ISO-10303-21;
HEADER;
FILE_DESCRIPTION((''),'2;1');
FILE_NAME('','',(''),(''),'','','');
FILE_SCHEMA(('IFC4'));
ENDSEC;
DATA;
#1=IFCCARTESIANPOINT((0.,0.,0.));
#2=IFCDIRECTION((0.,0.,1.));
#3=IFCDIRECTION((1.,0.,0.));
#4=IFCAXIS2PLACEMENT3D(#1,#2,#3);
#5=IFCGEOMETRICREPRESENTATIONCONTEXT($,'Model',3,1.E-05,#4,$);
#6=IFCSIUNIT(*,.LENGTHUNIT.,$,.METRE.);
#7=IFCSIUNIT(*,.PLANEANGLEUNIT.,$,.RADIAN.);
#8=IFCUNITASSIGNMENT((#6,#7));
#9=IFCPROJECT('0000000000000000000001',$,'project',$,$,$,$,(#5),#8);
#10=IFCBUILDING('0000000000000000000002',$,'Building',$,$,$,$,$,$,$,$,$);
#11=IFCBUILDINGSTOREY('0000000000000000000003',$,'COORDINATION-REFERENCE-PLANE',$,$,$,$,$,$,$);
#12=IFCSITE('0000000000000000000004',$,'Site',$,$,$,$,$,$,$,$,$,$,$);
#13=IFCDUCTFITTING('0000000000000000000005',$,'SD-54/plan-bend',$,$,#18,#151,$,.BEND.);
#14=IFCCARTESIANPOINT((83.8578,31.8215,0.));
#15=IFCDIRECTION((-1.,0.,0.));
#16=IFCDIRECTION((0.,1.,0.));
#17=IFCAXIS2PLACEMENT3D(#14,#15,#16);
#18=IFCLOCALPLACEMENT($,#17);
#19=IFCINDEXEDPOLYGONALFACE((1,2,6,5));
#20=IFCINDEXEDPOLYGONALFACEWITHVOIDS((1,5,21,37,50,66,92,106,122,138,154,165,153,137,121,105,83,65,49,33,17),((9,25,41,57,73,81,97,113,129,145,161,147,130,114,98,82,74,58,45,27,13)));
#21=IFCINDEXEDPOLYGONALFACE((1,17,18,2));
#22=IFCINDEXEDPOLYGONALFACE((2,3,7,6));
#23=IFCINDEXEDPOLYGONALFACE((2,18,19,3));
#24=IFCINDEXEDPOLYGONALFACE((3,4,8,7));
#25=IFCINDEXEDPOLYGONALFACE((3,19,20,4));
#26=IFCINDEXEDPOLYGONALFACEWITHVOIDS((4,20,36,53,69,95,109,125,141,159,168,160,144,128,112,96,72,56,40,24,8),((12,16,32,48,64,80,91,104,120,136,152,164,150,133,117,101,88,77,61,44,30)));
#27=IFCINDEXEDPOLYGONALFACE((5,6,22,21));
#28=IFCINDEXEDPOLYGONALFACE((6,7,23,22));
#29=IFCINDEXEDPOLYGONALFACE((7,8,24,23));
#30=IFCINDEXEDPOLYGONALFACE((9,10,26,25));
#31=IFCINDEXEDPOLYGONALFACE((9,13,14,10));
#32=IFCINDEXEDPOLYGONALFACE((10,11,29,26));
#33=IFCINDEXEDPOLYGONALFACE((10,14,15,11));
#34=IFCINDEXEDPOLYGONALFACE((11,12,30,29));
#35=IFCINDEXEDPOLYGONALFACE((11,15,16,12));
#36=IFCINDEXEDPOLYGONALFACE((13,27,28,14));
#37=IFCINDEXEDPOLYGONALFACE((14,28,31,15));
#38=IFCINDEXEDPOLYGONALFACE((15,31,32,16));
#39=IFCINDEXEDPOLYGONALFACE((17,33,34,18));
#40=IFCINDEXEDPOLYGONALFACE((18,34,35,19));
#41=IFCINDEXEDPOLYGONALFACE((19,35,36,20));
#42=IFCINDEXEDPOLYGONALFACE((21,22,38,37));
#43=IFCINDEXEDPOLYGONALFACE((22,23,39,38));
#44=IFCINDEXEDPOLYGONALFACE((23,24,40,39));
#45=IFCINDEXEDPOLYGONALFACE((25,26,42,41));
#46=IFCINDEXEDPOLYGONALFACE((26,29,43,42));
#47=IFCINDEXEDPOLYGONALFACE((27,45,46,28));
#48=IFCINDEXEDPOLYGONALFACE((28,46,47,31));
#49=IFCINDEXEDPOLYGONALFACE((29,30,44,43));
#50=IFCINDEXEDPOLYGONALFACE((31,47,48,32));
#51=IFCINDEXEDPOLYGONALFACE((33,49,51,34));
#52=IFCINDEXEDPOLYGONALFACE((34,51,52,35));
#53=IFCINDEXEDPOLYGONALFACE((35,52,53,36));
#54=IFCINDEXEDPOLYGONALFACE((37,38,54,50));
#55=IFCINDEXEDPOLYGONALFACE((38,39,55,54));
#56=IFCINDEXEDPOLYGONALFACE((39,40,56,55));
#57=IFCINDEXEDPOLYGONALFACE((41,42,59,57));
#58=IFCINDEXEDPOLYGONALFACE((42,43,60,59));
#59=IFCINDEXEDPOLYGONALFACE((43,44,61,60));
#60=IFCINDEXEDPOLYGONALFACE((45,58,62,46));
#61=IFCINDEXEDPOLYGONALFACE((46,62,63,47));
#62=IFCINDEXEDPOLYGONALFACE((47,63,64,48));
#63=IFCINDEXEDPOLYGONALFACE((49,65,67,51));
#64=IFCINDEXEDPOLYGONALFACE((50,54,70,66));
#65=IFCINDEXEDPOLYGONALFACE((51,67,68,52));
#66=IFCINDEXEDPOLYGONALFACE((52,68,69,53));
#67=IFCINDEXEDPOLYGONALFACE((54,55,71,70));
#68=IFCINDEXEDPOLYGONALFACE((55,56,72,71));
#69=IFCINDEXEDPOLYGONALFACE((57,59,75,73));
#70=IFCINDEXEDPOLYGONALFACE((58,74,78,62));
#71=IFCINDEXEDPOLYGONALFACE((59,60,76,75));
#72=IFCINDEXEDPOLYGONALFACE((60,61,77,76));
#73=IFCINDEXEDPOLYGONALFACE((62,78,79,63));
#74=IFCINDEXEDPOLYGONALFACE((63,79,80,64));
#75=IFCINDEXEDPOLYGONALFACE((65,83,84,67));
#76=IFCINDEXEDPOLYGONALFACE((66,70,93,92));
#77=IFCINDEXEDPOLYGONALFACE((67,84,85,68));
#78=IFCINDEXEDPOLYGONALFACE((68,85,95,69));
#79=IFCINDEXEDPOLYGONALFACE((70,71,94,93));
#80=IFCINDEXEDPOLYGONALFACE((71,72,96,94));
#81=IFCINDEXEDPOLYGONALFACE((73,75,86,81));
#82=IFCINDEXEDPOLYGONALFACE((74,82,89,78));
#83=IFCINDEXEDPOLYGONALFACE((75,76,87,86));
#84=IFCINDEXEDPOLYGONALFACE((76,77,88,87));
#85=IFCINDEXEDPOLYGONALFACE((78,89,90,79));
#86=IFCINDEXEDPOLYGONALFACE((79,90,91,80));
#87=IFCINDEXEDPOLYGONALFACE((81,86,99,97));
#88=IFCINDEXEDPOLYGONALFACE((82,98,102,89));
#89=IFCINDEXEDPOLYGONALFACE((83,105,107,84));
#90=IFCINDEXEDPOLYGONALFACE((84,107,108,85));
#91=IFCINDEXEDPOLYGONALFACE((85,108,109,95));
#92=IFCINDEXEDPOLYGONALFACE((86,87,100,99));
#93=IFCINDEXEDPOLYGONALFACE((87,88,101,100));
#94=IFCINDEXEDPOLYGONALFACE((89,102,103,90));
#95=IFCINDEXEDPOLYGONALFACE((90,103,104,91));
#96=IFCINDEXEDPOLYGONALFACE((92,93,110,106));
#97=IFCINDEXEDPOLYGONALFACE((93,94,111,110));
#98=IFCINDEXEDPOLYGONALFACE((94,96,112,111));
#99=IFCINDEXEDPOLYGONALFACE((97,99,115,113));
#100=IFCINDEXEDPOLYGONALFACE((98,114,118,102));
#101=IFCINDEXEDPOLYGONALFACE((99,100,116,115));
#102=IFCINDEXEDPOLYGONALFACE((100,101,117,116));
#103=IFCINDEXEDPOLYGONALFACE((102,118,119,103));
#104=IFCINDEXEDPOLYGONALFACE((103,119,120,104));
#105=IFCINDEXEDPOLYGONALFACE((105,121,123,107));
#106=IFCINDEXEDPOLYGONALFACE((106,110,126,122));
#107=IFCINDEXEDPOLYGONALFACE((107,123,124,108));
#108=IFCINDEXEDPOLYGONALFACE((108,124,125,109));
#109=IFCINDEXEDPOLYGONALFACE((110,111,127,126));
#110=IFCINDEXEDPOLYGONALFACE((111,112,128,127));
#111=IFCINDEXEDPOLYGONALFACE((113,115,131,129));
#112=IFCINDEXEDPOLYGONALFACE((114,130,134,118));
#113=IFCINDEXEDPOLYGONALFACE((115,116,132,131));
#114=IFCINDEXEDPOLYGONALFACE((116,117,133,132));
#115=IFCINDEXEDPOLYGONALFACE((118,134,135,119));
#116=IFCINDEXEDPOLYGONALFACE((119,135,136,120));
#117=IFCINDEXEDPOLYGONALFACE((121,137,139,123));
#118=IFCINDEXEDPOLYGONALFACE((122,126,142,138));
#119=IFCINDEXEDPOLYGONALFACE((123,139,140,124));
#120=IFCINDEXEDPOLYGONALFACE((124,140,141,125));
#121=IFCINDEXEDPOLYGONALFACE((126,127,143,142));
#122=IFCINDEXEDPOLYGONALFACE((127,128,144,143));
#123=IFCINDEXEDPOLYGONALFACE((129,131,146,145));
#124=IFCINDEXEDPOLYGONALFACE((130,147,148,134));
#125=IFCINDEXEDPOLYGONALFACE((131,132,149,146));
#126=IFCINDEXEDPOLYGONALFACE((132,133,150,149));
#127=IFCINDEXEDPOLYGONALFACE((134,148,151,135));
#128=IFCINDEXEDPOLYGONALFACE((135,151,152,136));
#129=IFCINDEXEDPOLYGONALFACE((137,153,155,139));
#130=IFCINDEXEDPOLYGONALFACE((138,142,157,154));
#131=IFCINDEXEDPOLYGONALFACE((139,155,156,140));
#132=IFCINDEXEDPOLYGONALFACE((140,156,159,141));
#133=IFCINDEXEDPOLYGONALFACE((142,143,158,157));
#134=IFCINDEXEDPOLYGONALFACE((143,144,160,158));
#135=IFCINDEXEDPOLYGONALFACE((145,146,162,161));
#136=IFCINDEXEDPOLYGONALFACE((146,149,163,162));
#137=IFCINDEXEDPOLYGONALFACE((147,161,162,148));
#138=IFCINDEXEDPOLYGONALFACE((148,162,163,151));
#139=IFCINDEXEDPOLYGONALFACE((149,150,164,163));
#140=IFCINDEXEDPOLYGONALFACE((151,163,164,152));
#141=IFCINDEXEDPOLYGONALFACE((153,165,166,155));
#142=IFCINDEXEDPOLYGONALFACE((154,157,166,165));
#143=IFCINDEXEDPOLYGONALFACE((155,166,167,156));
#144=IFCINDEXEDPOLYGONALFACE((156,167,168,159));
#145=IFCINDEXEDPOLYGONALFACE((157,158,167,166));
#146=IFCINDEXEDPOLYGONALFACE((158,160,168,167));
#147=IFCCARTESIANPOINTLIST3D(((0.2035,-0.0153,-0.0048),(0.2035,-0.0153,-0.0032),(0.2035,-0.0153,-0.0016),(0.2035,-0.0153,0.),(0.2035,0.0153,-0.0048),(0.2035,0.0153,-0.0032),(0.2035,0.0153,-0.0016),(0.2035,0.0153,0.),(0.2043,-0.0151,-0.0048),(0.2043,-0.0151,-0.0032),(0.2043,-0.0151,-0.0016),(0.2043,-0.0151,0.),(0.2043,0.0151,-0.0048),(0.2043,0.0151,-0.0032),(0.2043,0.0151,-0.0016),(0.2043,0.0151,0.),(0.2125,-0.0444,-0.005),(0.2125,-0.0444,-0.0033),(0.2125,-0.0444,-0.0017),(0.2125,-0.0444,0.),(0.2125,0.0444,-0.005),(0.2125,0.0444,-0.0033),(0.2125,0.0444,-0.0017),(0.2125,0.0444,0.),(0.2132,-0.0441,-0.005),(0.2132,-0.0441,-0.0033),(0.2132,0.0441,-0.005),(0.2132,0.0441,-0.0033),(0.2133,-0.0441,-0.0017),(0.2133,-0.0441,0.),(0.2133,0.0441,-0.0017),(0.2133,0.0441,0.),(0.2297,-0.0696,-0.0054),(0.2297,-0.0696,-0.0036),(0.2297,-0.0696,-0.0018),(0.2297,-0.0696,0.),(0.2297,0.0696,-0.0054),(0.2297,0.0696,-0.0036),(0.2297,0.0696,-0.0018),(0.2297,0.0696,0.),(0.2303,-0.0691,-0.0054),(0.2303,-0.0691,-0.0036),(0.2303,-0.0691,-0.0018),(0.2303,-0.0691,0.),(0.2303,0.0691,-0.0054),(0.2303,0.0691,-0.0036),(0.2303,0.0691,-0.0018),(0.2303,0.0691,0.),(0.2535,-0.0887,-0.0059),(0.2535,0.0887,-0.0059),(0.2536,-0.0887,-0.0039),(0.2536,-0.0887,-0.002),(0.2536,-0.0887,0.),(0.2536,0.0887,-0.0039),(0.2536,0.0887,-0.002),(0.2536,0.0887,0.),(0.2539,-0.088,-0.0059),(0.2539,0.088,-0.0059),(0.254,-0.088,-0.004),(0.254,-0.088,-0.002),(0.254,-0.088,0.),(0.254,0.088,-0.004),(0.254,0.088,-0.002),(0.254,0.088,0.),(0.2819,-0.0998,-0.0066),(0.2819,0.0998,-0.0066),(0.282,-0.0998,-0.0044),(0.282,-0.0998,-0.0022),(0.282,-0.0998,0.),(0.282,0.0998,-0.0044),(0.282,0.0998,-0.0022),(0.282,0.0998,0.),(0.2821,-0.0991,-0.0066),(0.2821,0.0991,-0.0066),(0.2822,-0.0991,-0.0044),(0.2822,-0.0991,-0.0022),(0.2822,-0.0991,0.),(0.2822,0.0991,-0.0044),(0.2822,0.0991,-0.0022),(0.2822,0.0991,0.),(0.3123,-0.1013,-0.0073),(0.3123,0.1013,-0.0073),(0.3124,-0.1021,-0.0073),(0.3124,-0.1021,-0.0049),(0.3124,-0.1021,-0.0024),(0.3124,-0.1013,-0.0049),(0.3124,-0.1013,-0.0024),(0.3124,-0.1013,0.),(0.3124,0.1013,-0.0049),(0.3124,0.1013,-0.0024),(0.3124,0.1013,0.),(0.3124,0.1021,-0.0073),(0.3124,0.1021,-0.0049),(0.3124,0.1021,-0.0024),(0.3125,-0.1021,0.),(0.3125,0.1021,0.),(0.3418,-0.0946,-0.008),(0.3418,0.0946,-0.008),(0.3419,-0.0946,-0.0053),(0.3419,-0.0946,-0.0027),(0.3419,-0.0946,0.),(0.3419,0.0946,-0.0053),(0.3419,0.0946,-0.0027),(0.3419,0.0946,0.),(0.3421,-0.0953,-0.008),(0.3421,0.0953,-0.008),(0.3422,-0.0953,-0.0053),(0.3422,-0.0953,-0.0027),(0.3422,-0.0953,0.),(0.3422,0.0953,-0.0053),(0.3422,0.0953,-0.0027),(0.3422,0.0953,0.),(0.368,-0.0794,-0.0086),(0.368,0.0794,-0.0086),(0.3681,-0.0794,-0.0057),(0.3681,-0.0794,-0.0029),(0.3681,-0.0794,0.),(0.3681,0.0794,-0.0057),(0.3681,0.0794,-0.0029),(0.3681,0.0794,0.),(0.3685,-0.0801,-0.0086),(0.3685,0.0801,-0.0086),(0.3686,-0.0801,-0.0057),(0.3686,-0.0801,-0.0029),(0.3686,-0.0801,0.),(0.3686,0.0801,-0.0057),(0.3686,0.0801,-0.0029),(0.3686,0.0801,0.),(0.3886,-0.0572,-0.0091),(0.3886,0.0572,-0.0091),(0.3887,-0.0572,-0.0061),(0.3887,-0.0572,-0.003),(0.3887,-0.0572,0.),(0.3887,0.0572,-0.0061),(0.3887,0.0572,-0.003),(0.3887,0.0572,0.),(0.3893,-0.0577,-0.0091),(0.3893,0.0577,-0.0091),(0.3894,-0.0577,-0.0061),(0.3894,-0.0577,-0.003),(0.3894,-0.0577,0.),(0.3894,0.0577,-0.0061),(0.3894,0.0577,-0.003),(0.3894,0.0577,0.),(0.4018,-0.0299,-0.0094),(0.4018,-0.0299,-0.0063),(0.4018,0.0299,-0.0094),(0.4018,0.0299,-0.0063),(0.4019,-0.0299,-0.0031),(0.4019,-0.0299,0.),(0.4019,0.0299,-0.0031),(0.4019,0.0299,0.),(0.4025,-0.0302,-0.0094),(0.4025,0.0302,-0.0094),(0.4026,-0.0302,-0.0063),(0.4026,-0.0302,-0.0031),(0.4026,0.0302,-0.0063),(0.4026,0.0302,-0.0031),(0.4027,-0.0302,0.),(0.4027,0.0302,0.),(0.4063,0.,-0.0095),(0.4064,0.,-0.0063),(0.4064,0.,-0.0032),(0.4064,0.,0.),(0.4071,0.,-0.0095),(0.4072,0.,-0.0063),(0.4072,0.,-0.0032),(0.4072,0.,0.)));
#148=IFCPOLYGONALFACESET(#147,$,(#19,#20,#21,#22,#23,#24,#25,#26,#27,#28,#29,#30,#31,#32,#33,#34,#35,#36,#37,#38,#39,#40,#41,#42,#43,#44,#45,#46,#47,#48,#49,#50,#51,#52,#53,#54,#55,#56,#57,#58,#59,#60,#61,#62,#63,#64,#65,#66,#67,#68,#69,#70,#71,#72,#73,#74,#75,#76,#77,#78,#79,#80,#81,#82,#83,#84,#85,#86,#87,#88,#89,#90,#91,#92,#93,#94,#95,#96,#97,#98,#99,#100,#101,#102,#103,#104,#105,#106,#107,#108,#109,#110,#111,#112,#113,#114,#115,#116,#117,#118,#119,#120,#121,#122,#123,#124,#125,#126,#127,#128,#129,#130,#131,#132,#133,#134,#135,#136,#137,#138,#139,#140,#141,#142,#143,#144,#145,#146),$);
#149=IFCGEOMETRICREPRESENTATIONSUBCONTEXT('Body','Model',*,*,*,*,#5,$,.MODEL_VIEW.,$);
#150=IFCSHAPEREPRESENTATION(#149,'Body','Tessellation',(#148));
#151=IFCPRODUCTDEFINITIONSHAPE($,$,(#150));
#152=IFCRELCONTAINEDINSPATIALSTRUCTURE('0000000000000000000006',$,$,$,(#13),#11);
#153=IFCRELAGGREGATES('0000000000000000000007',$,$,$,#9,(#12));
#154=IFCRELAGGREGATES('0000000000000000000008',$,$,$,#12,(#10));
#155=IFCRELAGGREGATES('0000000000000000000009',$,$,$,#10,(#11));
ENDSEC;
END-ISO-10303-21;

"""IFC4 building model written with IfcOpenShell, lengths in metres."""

from ifc_helpers import new_model, entity, si_unit, frame, origin_with_axes, place, context, subcontext, project, spatial, element, save


model = new_model("IFC4")

# Units and contexts
model_context = context("Model", 3, precision=1e-05, world=origin_with_axes())
body_context_1 = subcontext(model_context, "Body", "Model", "MODEL_VIEW")
ifc_project = project(units=[si_unit("LENGTHUNIT", "METRE"), si_unit("PLANEANGLEUNIT", "RADIAN")], contexts=[model_context])

# Site, building, storey
site = spatial("IfcSite", under=ifc_project, Name="Site")
building = spatial("IfcBuilding", under=site, Name="Building")
storey = spatial("IfcBuildingStorey", under=building, Name="COORDINATION-REFERENCE-PLANE")

# Duct fitting
duct_fitting_1_placement = place(None, frame((83.8578, 31.8215, 0.0), z_axis=(-1.0, 0.0, 0.0), x_axis=(0.0, 1.0, 0.0)))
element("IfcDuctFitting", 1, at=duct_fitting_1_placement, inside=storey, Name="SD-54/plan-bend", PredefinedType="BEND", context=body_context_1, shape_type="SweptSolid", body=[
    entity("IfcRevolvedAreaSolid", entity("IfcCircleHollowProfileDef", "AREA", None, entity("IfcAxis2Placement2D", entity("IfcCartesianPoint", [0.3048, 0.0])), 0.1024, 0.0008), entity("IfcAxis2Placement3D", entity("IfcCartesianPoint", [0.0, 0.0, 0.0]), entity("IfcDirection", [0.0, 0.0, 1.0]), entity("IfcDirection", [1.0, 0.0, 0.0])), entity("IfcAxis1Placement", entity("IfcCartesianPoint", [0.0, 0.0, 0.0]), entity("IfcDirection", [0.0, 1.0, 0.0])), 0.023363),
])

save(model, "model.ifc")
